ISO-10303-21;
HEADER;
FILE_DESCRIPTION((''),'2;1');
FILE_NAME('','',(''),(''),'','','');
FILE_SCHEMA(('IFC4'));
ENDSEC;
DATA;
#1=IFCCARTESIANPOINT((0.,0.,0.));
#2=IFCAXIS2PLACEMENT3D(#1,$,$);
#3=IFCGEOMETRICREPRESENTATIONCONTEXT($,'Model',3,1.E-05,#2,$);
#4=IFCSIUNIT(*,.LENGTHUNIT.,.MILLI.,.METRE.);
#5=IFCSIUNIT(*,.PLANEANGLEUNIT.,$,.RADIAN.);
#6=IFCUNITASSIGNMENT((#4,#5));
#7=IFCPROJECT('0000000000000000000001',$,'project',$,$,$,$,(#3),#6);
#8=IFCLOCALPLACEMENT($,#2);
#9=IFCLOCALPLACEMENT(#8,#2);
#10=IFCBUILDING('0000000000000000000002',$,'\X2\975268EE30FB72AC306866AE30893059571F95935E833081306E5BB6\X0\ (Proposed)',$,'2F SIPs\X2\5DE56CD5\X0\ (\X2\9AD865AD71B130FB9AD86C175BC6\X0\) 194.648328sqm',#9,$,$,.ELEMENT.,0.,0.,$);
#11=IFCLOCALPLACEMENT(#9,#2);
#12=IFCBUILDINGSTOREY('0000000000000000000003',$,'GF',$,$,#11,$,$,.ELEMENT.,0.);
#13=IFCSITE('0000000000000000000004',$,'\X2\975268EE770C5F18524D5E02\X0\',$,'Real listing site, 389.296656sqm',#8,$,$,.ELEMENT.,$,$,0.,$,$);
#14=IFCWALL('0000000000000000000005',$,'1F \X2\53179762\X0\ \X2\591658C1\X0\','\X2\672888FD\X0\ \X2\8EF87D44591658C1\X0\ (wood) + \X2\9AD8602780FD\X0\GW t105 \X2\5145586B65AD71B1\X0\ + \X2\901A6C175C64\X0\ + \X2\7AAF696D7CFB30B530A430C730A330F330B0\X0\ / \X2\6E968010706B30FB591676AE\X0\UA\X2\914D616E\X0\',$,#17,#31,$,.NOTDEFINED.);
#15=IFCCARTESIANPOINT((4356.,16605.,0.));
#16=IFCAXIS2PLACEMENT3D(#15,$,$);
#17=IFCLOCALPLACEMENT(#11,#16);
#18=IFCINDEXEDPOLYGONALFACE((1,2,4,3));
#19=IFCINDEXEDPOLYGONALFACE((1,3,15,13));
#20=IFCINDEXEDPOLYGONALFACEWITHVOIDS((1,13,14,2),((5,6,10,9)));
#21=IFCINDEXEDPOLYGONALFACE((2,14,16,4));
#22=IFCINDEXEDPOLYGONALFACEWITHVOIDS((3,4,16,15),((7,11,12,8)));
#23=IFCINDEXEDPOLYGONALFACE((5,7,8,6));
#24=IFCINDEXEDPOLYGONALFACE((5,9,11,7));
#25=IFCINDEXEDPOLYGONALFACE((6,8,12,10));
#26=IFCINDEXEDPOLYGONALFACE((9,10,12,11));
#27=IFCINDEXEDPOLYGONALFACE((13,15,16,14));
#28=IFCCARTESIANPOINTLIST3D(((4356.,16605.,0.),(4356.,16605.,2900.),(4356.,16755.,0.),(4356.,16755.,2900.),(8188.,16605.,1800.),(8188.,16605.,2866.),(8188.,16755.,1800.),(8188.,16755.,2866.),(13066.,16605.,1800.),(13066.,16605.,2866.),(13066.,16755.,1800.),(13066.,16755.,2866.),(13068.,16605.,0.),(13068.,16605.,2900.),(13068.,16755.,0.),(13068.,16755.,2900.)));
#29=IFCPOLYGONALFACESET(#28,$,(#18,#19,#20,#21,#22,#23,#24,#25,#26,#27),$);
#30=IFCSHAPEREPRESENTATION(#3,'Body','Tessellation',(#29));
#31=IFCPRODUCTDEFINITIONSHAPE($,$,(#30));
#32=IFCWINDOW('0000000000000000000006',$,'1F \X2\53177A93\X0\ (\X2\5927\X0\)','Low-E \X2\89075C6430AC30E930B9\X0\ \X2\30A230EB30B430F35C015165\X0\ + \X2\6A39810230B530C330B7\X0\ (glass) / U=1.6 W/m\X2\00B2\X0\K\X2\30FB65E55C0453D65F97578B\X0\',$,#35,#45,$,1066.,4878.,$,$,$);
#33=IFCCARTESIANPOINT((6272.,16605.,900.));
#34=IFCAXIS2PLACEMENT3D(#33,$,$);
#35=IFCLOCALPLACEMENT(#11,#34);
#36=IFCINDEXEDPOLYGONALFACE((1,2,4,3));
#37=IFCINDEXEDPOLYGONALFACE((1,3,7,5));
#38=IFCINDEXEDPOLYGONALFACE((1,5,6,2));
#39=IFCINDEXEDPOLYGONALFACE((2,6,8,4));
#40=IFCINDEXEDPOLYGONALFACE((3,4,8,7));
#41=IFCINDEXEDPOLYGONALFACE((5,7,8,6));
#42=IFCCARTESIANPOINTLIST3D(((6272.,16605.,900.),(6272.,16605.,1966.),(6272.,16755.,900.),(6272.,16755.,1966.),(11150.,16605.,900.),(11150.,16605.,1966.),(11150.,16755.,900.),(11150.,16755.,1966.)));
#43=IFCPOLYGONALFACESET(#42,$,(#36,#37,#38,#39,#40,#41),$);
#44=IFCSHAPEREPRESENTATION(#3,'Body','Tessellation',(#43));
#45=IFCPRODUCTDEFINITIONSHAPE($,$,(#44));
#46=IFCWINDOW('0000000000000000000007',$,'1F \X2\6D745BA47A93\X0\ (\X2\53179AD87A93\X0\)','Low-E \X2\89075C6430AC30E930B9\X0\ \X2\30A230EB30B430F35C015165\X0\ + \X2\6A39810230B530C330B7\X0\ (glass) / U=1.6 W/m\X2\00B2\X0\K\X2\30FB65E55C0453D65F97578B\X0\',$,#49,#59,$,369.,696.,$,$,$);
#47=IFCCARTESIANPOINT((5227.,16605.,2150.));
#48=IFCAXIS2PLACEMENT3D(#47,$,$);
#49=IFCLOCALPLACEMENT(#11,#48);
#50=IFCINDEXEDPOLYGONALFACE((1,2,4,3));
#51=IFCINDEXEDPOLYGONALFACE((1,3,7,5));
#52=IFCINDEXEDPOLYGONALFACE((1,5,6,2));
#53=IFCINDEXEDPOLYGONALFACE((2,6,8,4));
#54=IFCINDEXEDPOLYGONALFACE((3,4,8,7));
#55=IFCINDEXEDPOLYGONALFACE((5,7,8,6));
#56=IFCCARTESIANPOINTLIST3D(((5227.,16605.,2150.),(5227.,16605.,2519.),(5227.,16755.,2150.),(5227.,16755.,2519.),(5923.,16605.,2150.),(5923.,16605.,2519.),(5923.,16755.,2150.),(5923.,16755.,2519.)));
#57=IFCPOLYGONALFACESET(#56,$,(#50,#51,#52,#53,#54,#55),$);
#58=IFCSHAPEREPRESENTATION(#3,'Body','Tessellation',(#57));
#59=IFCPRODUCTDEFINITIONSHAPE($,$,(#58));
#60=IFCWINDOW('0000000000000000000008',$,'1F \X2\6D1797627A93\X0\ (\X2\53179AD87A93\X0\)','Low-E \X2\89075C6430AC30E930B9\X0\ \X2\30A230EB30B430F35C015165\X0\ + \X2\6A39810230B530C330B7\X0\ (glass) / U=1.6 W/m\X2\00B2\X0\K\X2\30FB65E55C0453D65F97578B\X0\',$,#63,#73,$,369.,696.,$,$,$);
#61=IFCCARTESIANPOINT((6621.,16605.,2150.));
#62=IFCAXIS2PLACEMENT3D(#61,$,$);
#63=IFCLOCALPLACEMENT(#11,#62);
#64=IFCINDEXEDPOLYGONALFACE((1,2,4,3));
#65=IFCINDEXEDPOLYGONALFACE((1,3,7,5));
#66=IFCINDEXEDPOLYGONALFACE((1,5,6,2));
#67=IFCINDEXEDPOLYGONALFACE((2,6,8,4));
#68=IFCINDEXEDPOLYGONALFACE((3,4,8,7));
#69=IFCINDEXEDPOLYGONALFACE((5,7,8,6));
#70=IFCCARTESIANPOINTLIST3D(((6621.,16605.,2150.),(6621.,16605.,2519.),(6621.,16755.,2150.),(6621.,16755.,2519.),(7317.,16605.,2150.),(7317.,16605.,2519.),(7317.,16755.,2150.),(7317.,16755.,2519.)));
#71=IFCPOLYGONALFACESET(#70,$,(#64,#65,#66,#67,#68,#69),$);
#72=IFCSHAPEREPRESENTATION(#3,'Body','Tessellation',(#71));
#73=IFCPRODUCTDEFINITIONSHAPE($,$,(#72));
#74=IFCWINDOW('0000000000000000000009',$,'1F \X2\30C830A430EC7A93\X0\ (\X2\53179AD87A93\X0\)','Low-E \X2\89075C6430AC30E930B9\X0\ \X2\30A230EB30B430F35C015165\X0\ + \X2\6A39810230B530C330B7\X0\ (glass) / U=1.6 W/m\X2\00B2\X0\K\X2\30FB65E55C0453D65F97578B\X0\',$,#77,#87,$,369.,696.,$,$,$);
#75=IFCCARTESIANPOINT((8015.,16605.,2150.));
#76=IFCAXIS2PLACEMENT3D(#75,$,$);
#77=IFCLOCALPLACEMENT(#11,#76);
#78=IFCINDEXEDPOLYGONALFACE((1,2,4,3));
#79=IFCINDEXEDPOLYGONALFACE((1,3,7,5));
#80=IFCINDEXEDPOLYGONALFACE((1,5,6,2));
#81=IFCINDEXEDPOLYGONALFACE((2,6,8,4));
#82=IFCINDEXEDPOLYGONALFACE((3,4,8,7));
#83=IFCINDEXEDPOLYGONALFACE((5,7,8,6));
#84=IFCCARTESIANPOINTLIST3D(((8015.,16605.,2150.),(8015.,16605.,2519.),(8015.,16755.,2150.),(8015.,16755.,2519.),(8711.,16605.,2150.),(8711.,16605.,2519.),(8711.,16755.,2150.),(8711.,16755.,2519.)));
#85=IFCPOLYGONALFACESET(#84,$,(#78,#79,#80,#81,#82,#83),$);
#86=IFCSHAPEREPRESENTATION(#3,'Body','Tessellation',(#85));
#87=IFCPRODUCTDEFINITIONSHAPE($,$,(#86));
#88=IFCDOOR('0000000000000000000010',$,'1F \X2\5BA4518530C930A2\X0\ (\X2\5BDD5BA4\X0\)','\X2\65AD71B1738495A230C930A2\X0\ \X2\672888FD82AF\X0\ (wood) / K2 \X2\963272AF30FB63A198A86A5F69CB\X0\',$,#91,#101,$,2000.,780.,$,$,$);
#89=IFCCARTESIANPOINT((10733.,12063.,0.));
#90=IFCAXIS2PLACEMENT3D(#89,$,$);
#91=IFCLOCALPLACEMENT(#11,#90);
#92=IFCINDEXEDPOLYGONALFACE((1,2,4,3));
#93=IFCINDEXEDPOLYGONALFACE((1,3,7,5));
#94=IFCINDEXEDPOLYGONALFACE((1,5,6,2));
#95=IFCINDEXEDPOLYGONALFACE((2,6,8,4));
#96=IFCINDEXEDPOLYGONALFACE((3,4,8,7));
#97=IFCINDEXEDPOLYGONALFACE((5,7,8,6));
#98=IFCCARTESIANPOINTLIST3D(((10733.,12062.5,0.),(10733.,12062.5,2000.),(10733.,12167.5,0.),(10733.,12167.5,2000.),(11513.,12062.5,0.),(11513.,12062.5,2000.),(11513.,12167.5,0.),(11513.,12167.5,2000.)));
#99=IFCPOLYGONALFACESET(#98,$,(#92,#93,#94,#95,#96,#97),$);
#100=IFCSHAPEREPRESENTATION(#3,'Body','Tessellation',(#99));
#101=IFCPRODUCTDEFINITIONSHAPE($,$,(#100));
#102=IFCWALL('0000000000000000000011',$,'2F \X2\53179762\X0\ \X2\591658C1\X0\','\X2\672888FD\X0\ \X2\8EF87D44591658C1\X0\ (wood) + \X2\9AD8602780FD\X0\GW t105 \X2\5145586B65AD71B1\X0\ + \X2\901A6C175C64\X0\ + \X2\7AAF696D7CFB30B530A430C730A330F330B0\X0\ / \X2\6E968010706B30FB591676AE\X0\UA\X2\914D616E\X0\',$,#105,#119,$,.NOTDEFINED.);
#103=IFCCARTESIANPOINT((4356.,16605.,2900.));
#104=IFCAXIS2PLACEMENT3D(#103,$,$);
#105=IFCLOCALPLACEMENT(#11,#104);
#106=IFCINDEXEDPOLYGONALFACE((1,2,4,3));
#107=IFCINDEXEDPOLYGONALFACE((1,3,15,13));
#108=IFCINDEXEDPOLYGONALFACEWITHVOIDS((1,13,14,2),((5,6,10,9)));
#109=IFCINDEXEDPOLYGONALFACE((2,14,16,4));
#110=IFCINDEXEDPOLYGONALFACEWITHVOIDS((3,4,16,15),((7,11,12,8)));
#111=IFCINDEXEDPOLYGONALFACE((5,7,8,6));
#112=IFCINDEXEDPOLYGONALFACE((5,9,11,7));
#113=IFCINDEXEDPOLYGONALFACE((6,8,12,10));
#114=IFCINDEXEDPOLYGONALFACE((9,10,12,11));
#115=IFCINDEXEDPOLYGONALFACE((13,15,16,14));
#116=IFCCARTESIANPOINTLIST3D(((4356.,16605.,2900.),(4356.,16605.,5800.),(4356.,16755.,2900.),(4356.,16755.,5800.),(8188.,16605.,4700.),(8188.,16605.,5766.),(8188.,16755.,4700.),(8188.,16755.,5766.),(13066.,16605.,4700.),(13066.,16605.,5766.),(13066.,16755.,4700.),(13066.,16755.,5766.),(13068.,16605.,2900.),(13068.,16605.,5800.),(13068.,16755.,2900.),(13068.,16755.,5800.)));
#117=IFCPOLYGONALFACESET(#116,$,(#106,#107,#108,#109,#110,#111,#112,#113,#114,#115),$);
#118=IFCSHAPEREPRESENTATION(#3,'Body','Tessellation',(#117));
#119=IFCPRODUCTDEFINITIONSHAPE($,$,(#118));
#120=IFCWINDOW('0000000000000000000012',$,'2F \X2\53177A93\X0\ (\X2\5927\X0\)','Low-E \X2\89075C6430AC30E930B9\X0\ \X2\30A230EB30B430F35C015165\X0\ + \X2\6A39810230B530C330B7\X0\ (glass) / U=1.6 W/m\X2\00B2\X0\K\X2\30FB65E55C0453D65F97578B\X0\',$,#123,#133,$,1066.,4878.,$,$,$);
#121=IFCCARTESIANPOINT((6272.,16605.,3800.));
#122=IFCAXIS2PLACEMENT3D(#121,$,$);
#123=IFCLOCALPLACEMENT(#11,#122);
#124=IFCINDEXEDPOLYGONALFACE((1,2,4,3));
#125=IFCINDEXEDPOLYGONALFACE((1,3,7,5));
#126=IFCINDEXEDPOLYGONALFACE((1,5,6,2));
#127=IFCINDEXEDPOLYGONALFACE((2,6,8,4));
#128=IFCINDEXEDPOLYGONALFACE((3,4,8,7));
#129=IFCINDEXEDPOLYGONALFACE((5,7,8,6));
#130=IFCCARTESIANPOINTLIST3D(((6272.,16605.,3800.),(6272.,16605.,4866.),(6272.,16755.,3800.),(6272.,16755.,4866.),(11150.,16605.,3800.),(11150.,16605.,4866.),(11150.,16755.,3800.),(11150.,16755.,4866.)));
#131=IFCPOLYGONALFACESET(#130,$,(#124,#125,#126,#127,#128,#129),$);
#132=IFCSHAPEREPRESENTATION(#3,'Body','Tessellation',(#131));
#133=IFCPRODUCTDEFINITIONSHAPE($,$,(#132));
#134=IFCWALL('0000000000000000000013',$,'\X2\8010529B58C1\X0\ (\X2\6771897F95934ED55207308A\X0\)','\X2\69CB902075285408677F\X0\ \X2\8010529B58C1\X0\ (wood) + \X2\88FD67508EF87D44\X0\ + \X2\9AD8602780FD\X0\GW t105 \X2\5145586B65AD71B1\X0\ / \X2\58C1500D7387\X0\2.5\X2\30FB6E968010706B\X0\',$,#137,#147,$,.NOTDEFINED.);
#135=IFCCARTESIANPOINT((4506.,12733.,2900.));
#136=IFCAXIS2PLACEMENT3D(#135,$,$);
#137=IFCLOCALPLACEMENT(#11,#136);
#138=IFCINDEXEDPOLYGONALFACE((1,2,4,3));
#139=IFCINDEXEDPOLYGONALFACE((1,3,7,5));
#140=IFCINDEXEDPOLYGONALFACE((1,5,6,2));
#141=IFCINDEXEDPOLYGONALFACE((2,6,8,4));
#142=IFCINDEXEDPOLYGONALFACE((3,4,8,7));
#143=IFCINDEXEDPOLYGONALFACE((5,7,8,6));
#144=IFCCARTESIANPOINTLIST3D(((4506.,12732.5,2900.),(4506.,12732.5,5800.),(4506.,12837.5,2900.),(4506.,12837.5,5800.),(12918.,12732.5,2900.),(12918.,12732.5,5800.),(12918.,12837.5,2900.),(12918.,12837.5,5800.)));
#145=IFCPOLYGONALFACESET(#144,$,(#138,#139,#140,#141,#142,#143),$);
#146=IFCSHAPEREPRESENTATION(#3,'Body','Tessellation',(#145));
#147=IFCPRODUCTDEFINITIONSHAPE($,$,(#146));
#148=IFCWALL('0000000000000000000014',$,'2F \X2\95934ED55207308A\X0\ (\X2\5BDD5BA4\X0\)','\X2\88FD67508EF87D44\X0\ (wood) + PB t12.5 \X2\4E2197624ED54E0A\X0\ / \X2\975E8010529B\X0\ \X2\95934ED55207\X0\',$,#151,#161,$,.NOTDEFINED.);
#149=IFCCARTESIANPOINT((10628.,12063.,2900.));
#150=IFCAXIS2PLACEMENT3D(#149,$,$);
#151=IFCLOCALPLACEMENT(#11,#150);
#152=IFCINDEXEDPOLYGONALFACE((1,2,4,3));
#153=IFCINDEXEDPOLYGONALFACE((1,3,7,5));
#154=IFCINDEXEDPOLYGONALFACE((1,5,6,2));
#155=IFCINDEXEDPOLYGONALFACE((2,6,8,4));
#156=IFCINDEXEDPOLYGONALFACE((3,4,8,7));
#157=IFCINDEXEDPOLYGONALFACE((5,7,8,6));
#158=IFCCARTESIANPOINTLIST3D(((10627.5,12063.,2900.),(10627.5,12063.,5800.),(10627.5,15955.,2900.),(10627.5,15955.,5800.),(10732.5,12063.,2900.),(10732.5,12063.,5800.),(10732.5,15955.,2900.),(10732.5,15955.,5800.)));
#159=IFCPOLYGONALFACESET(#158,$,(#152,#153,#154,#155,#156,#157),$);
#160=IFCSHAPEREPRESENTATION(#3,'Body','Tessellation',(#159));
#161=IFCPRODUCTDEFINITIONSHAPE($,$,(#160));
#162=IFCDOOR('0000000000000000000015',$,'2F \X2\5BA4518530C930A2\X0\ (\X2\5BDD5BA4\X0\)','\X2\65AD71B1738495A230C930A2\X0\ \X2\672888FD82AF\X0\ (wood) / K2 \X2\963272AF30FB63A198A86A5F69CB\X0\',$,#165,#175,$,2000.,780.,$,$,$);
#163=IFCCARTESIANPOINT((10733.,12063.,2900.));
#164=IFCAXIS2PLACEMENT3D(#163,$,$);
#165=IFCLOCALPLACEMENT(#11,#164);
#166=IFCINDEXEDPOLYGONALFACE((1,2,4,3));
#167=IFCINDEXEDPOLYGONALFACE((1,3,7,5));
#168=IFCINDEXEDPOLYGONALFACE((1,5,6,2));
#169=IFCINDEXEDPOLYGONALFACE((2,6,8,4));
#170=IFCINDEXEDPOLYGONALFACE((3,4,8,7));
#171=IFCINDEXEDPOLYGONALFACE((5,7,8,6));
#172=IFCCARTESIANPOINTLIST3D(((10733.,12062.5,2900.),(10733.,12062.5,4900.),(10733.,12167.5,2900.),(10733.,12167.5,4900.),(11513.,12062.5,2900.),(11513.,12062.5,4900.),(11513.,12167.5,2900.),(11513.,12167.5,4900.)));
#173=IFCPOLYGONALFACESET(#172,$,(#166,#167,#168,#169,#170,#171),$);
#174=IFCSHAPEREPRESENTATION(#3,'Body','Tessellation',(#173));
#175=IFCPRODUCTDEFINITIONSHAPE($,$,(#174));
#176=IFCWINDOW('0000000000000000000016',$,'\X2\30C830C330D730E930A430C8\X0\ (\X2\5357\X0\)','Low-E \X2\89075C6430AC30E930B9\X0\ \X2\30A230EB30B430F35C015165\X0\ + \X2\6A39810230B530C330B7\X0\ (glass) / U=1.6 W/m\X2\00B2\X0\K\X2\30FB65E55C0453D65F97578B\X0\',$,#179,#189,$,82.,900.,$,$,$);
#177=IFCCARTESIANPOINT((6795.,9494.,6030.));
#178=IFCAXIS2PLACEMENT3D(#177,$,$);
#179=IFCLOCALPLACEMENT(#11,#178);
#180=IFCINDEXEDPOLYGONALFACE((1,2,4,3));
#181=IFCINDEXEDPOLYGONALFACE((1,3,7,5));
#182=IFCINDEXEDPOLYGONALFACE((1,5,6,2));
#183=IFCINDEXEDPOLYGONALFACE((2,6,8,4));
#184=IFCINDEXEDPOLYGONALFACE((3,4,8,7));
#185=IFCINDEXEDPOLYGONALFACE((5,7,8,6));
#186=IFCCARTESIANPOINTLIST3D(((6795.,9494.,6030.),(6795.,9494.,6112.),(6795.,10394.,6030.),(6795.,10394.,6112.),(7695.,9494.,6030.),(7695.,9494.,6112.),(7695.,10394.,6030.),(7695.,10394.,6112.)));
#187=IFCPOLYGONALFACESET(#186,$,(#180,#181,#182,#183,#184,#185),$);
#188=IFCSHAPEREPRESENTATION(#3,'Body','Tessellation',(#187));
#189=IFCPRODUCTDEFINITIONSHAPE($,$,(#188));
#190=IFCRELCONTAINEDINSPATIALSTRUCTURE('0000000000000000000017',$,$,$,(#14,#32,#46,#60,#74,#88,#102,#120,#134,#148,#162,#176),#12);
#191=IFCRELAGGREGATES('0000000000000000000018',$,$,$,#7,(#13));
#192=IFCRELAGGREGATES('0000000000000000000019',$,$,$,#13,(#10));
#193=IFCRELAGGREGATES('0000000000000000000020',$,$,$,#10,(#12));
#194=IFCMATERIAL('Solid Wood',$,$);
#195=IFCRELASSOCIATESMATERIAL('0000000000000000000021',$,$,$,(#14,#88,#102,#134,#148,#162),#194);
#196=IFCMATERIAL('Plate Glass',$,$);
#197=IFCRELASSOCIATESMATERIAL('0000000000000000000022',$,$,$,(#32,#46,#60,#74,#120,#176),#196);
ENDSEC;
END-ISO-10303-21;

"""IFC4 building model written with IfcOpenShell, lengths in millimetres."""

from ifc_helpers import new_model, si_unit, frame, frame_2d, origin, place, context, project, spatial, rectangle, extrude, material, element, fill, save


model = new_model("IFC4")

# Units and contexts
model_context = context("Model", 3, precision=1e-05, world=origin())
ifc_project = project(units=[si_unit("LENGTHUNIT", "METRE", prefix="MILLI"), si_unit("PLANEANGLEUNIT", "RADIAN")], contexts=[model_context])

# Site, building, storey
site_placement = place(None, origin())
site = spatial("IfcSite", under=ifc_project, at=site_placement, Name="青森県弘前市", ObjectType="Real listing site, 389.296656sqm", CompositionType="ELEMENT", RefElevation=0.0)
building_placement = place(site_placement, origin())
building = spatial("IfcBuilding", under=site, at=building_placement, Name="青森・犬と暮らす土間広めの家 (Proposed)", ObjectType="2F SIPs工法 (高断熱・高気密) 194.648328sqm", CompositionType="ELEMENT", ElevationOfRefHeight=0.0, ElevationOfTerrain=0.0)
storey_placement = place(building_placement, origin())
storey = spatial("IfcBuildingStorey", under=building, at=storey_placement, Name="GF", CompositionType="ELEMENT", Elevation=0.0)

# Wall, openings, windows
ifc_material_1 = material(Name="Solid Wood")
wall_1_placement = place(storey_placement, frame((4356.0, 16605.0, 0.0)))
wall_1 = element("IfcWall", 1, at=wall_1_placement, inside=storey, material=ifc_material_1, Name="1F 北面 外壁", Description="木製 軸組外壁 (wood) + 高性能GW t105 充填断熱 + 通気層 + 窯業系サイディング / 準耐火・外皮UA配慮", PredefinedType="NOTDEFINED", context=model_context, shape_type="SweptSolid", body=[
    extrude(rectangle(XDim=8712.0, YDim=150.0, at=frame_2d((4356.0, 75.0))), frame((4356.0, 16605.0, 0.0)), (0.0, 0.0, 1.0), 2900.0),
])
opening_1_placement = place(storey_placement, frame((6272.0, 16605.0, 900.0)))
opening_1 = element("IfcOpeningElement", 2, at=opening_1_placement, cuts=wall_1, PredefinedType="NOTDEFINED", context=model_context, shape_type="SweptSolid", body=[
    extrude(rectangle(XDim=4878.0, YDim=150.0, at=frame_2d((2439.0, 75.0))), frame((6272.0, 16605.0, 900.0)), (0.0, 0.0, 1.0), 1066.0),
])
opening_2_placement = place(storey_placement, frame((5227.0, 16605.0, 2150.0)))
opening_2 = element("IfcOpeningElement", 3, at=opening_2_placement, cuts=wall_1, PredefinedType="NOTDEFINED", context=model_context, shape_type="SweptSolid", body=[
    extrude(rectangle(XDim=696.0, YDim=150.0, at=frame_2d((348.0, 75.0))), frame((5227.0, 16605.0, 2150.0)), (0.0, 0.0, 1.0), 369.0),
])
opening_3_placement = place(storey_placement, frame((6621.0, 16605.0, 2150.0)))
opening_3 = element("IfcOpeningElement", 4, at=opening_3_placement, cuts=wall_1, PredefinedType="NOTDEFINED", context=model_context, shape_type="SweptSolid", body=[
    extrude(rectangle(XDim=696.0, YDim=150.0, at=frame_2d((348.0, 75.0))), frame((6621.0, 16605.0, 2150.0)), (0.0, 0.0, 1.0), 369.0),
])
opening_4_placement = place(storey_placement, frame((8015.0, 16605.0, 2150.0)))
opening_4 = element("IfcOpeningElement", 5, at=opening_4_placement, cuts=wall_1, PredefinedType="NOTDEFINED", context=model_context, shape_type="SweptSolid", body=[
    extrude(rectangle(XDim=696.0, YDim=150.0, at=frame_2d((348.0, 75.0))), frame((8015.0, 16605.0, 2150.0)), (0.0, 0.0, 1.0), 369.0),
])
ifc_material_2 = material(Name="Plate Glass")
window_1_placement = place(storey_placement, frame((6272.0, 16605.0, 900.0)))
window_1 = element("IfcWindow", 6, at=window_1_placement, inside=storey, material=ifc_material_2, Name="1F 北窓 (大)", Description="Low-E 複層ガラス アルゴン封入 + 樹脂サッシ (glass) / U=1.6 W/m²K・日射取得型", OverallHeight=1066.0, OverallWidth=4878.0, context=model_context, shape_type="SweptSolid", body=[
    extrude(rectangle(XDim=4878.0, YDim=150.0, at=frame_2d((2439.0, 75.0))), frame((6272.0, 16605.0, 900.0)), (0.0, 0.0, 1.0), 1066.0),
])
fill(opening_1, window_1)
window_2_placement = place(storey_placement, frame((5227.0, 16605.0, 2150.0)))
window_2 = element("IfcWindow", 7, at=window_2_placement, inside=storey, material=ifc_material_2, Name="1F 浴室窓 (北高窓)", Description="Low-E 複層ガラス アルゴン封入 + 樹脂サッシ (glass) / U=1.6 W/m²K・日射取得型", OverallHeight=369.0, OverallWidth=696.0, context=model_context, shape_type="SweptSolid", body=[
    extrude(rectangle(XDim=696.0, YDim=150.0, at=frame_2d((348.0, 75.0))), frame((5227.0, 16605.0, 2150.0)), (0.0, 0.0, 1.0), 369.0),
])
fill(opening_2, window_2)
window_3_placement = place(storey_placement, frame((6621.0, 16605.0, 2150.0)))
window_3 = element("IfcWindow", 8, at=window_3_placement, inside=storey, material=ifc_material_2, Name="1F 洗面窓 (北高窓)", Description="Low-E 複層ガラス アルゴン封入 + 樹脂サッシ (glass) / U=1.6 W/m²K・日射取得型", OverallHeight=369.0, OverallWidth=696.0, context=model_context, shape_type="SweptSolid", body=[
    extrude(rectangle(XDim=696.0, YDim=150.0, at=frame_2d((348.0, 75.0))), frame((6621.0, 16605.0, 2150.0)), (0.0, 0.0, 1.0), 369.0),
])
fill(opening_3, window_3)
window_4_placement = place(storey_placement, frame((8015.0, 16605.0, 2150.0)))
window_4 = element("IfcWindow", 9, at=window_4_placement, inside=storey, material=ifc_material_2, Name="1F トイレ窓 (北高窓)", Description="Low-E 複層ガラス アルゴン封入 + 樹脂サッシ (glass) / U=1.6 W/m²K・日射取得型", OverallHeight=369.0, OverallWidth=696.0, context=model_context, shape_type="SweptSolid", body=[
    extrude(rectangle(XDim=696.0, YDim=150.0, at=frame_2d((348.0, 75.0))), frame((8015.0, 16605.0, 2150.0)), (0.0, 0.0, 1.0), 369.0),
])
fill(opening_4, window_4)

# Door
door_1_placement = place(storey_placement, frame((10733.0, 12063.0, 0.0)))
element("IfcDoor", 10, at=door_1_placement, inside=storey, material=ifc_material_1, Name="1F 室内ドア (寝室)", Description="断熱玄関ドア 木製芯 (wood) / K2 防犯・採風機構", OverallHeight=2000.0, OverallWidth=780.0, context=model_context, shape_type="SweptSolid", body=[
    extrude(rectangle(XDim=780.0, YDim=105.0, at=frame_2d((390.0, 52.0))), frame((10733.0, 12063.0, 0.0)), (0.0, 0.0, 1.0), 2000.0),
])

# Wall, opening, window
wall_2_placement = place(storey_placement, frame((4356.0, 16605.0, 2900.0)))
wall_2 = element("IfcWall", 11, at=wall_2_placement, inside=storey, material=ifc_material_1, Name="2F 北面 外壁", Description="木製 軸組外壁 (wood) + 高性能GW t105 充填断熱 + 通気層 + 窯業系サイディング / 準耐火・外皮UA配慮", PredefinedType="NOTDEFINED", context=model_context, shape_type="SweptSolid", body=[
    extrude(rectangle(XDim=8712.0, YDim=150.0, at=frame_2d((4356.0, 75.0))), frame((4356.0, 16605.0, 2900.0)), (0.0, 0.0, 1.0), 2900.0),
])
opening_5_placement = place(storey_placement, frame((6272.0, 16605.0, 3800.0)))
opening_5 = element("IfcOpeningElement", 12, at=opening_5_placement, cuts=wall_2, PredefinedType="NOTDEFINED", context=model_context, shape_type="SweptSolid", body=[
    extrude(rectangle(XDim=4878.0, YDim=150.0, at=frame_2d((2439.0, 75.0))), frame((6272.0, 16605.0, 3800.0)), (0.0, 0.0, 1.0), 1066.0),
])
window_5_placement = place(storey_placement, frame((6272.0, 16605.0, 3800.0)))
window_5 = element("IfcWindow", 13, at=window_5_placement, inside=storey, material=ifc_material_2, Name="2F 北窓 (大)", Description="Low-E 複層ガラス アルゴン封入 + 樹脂サッシ (glass) / U=1.6 W/m²K・日射取得型", OverallHeight=1066.0, OverallWidth=4878.0, context=model_context, shape_type="SweptSolid", body=[
    extrude(rectangle(XDim=4878.0, YDim=150.0, at=frame_2d((2439.0, 75.0))), frame((6272.0, 16605.0, 3800.0)), (0.0, 0.0, 1.0), 1066.0),
])
fill(opening_5, window_5)

# Walls
wall_3_placement = place(storey_placement, frame((4506.0, 12733.0, 2900.0)))
element("IfcWall", 14, at=wall_3_placement, inside=storey, material=ifc_material_1, Name="耐力壁 (東西間仕切り)", Description="構造用合板 耐力壁 (wood) + 製材軸組 + 高性能GW t105 充填断熱 / 壁倍率2.5・準耐火", PredefinedType="NOTDEFINED", context=model_context, shape_type="SweptSolid", body=[
    extrude(rectangle(XDim=8412.0, YDim=105.0, at=frame_2d((4206.0, 52.0))), frame((4506.0, 12733.0, 2900.0)), (0.0, 0.0, 1.0), 2900.0),
])
wall_4_placement = place(storey_placement, frame((10628.0, 12063.0, 2900.0)))
element("IfcWall", 15, at=wall_4_placement, inside=storey, material=ifc_material_1, Name="2F 間仕切り (寝室)", Description="製材軸組 (wood) + PB t12.5 両面仕上 / 非耐力 間仕切", PredefinedType="NOTDEFINED", context=model_context, shape_type="SweptSolid", body=[
    extrude(rectangle(XDim=105.0, YDim=3892.0, at=frame_2d((52.0, 1946.0))), frame((10628.0, 12063.0, 2900.0)), (0.0, 0.0, 1.0), 2900.0),
])

# Door
door_2_placement = place(storey_placement, frame((10733.0, 12063.0, 2900.0)))
element("IfcDoor", 16, at=door_2_placement, inside=storey, material=ifc_material_1, Name="2F 室内ドア (寝室)", Description="断熱玄関ドア 木製芯 (wood) / K2 防犯・採風機構", OverallHeight=2000.0, OverallWidth=780.0, context=model_context, shape_type="SweptSolid", body=[
    extrude(rectangle(XDim=780.0, YDim=105.0, at=frame_2d((390.0, 52.0))), frame((10733.0, 12063.0, 2900.0)), (0.0, 0.0, 1.0), 2000.0),
])

# Window
window_6_placement = place(storey_placement, frame((6795.0, 9494.0, 6030.0)))
element("IfcWindow", 17, at=window_6_placement, inside=storey, material=ifc_material_2, Name="トップライト (南)", Description="Low-E 複層ガラス アルゴン封入 + 樹脂サッシ (glass) / U=1.6 W/m²K・日射取得型", OverallHeight=82.0, OverallWidth=900.0, context=model_context, shape_type="SweptSolid", body=[
    extrude(rectangle(XDim=900.0, YDim=900.0, at=frame_2d((450.0, 450.0))), frame((6795.0, 9494.0, 6030.0)), (0.0, 0.0, 1.0), 82.0),
])

save(model, "model.ifc")
